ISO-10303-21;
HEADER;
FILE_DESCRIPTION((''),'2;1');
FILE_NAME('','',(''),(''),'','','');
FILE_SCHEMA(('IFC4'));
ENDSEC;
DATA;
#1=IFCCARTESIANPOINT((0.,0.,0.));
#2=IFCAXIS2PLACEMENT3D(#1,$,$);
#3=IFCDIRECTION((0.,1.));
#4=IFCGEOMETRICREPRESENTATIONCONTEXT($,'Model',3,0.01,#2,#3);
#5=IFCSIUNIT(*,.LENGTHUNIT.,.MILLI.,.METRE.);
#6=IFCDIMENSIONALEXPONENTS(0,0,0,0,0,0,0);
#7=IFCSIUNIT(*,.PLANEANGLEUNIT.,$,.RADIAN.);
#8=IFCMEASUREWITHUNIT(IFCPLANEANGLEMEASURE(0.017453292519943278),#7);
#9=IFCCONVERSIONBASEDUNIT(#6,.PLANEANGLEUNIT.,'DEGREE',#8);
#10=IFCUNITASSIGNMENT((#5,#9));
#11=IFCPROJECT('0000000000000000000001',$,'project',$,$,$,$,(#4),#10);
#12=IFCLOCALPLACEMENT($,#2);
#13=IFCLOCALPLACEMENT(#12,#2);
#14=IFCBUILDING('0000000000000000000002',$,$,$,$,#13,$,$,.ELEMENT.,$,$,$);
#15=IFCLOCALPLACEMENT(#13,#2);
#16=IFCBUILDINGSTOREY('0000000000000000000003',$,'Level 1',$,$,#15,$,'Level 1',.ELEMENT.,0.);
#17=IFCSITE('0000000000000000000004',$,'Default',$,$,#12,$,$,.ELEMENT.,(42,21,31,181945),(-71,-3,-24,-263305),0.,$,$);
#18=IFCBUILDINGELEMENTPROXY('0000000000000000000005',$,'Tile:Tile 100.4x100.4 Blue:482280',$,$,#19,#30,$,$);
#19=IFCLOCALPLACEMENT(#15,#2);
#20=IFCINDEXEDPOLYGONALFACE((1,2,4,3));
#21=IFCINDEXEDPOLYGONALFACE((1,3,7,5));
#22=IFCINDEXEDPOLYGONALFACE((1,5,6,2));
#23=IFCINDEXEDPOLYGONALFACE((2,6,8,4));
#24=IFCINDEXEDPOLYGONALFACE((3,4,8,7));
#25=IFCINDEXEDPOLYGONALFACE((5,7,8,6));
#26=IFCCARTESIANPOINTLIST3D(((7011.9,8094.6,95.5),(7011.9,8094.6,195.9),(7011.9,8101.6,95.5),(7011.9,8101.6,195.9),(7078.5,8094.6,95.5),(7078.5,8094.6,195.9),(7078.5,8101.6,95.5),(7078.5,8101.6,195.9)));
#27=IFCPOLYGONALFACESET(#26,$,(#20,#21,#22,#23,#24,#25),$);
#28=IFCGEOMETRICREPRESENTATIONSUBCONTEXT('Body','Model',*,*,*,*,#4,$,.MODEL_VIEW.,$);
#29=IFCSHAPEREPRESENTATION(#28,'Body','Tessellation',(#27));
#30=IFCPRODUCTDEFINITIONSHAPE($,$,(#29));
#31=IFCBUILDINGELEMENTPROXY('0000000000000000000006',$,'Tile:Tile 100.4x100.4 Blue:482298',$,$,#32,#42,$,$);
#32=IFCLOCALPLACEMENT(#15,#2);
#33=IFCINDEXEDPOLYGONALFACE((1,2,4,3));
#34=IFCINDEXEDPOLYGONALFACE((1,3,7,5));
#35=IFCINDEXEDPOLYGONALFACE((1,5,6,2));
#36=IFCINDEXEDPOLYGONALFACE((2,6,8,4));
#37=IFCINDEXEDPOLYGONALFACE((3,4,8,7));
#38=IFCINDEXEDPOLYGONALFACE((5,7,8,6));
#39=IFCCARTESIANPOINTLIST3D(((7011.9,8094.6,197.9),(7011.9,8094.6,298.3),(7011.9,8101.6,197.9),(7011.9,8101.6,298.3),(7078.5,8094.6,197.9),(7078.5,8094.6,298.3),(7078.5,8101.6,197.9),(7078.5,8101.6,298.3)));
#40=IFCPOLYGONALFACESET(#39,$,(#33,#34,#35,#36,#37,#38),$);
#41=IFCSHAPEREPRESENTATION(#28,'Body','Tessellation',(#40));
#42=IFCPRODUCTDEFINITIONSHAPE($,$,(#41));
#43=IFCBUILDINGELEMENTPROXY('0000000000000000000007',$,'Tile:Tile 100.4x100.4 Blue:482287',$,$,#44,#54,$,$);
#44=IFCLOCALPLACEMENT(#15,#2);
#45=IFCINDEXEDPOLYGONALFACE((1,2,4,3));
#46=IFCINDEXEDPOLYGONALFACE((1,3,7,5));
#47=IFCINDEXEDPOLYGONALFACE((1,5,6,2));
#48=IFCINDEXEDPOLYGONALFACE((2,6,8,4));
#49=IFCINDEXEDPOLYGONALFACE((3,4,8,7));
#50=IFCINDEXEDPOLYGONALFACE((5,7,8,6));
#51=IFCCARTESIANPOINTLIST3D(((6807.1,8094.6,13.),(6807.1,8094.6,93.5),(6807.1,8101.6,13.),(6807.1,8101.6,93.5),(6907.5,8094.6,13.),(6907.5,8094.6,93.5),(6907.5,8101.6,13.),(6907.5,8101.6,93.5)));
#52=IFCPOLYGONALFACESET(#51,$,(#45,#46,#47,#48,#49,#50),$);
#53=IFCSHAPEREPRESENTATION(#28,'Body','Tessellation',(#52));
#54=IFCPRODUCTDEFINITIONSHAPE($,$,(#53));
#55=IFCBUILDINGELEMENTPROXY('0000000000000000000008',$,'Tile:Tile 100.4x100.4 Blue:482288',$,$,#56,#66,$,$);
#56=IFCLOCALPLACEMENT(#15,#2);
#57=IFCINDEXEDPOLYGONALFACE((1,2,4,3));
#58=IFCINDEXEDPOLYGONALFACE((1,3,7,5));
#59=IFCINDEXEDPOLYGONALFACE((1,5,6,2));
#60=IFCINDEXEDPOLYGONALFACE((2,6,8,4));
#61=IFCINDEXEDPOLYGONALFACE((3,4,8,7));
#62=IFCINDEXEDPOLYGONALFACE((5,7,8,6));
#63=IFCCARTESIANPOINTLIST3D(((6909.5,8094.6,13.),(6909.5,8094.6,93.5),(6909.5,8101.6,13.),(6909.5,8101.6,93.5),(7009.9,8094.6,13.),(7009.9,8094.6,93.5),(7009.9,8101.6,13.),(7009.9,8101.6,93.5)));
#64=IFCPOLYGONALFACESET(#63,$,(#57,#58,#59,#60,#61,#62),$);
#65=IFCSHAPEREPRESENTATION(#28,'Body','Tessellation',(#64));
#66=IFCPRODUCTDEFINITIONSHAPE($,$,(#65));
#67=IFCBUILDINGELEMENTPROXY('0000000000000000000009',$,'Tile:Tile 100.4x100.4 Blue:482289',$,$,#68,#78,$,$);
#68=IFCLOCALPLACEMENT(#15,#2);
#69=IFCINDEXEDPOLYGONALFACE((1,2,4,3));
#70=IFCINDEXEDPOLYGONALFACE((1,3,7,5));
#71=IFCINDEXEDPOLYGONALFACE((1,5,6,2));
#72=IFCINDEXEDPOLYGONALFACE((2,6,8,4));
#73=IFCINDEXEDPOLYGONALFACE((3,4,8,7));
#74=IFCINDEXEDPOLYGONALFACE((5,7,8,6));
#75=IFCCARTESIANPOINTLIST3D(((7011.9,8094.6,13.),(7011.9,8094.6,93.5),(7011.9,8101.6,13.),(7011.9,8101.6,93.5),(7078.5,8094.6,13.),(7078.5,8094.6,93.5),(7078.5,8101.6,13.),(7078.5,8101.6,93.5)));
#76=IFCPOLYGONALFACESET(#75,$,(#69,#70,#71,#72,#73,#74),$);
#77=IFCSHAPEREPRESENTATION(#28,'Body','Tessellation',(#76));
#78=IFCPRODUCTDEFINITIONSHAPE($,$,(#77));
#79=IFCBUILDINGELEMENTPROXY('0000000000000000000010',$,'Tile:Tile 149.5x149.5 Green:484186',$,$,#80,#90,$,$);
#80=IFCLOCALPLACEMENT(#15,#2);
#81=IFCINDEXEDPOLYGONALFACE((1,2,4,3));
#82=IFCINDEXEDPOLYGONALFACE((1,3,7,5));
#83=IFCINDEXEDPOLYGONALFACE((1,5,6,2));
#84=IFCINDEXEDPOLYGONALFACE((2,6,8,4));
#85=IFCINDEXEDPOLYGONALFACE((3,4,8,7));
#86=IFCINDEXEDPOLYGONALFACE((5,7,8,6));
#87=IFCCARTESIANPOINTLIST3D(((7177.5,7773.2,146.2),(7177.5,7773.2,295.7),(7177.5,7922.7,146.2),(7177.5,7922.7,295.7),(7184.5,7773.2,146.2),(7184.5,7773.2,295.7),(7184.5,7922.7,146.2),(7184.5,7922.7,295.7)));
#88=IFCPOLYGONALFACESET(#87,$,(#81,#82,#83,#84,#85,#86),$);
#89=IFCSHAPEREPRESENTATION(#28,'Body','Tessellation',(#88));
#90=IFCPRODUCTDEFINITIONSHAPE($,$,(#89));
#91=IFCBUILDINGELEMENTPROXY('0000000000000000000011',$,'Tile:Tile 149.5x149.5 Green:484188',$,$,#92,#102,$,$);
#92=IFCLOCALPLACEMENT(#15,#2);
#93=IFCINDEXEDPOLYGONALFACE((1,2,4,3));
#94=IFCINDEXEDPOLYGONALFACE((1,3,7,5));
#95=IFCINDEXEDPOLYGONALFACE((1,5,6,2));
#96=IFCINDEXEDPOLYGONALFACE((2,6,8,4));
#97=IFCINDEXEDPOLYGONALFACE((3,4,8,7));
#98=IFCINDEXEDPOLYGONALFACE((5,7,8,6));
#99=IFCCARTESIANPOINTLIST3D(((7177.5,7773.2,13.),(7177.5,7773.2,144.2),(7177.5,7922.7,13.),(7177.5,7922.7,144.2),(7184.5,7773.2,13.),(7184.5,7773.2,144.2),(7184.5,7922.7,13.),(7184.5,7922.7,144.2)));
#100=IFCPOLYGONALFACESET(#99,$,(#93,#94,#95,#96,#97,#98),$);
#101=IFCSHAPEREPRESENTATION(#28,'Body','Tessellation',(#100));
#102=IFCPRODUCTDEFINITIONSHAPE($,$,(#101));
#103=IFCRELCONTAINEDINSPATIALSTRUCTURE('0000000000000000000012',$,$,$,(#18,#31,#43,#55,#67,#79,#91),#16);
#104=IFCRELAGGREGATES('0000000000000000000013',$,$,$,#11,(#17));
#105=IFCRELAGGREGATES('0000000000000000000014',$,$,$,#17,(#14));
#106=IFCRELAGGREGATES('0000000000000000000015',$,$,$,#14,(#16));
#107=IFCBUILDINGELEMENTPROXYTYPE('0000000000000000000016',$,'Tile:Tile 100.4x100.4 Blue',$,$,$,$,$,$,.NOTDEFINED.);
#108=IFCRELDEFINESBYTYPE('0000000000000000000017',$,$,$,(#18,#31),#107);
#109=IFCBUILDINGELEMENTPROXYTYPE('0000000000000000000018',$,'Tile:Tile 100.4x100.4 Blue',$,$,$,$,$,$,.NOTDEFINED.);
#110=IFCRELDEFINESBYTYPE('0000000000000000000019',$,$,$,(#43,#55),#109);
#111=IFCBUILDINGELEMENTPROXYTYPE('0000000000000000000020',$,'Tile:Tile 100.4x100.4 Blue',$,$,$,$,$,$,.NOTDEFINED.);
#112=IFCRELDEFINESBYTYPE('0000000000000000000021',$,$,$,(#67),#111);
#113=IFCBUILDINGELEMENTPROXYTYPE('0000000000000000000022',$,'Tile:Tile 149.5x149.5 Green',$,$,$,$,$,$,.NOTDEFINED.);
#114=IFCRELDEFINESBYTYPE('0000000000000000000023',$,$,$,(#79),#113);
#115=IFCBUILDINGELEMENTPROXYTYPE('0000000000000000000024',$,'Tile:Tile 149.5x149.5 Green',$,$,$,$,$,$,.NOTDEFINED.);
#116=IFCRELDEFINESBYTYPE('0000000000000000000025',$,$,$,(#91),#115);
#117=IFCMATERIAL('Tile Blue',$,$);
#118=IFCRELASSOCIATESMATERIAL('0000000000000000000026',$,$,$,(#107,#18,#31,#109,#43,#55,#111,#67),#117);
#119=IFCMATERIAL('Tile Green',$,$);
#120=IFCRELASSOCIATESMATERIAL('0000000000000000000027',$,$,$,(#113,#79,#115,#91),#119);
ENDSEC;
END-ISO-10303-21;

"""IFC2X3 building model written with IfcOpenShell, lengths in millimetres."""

from ifc_helpers import new_model, entity, si_unit, converted_unit, direction, frame, origin, origin_2d_with_axis, place, context, subcontext, project, spatial, rectangle, extrude, source, transform, mapped, material, type_object, type_shapes, element, save


model = new_model("IFC2X3")

# Units and contexts
model_context = context("Model", 3, precision=0.01, world=origin(), true_north=direction((0.0, 1.0)))
body_context = subcontext(model_context, "Body", "Model", "MODEL_VIEW")
ifc_project = project(units=[si_unit("LENGTHUNIT", "METRE", prefix="MILLI"), converted_unit("PLANEANGLEUNIT", "DEGREE", entity("IfcPlaneAngleMeasure", 0.017453292519943278), si_unit("PLANEANGLEUNIT", "RADIAN"), dimensions=[0, 0, 0, 0, 0, 0, 0])], contexts=[model_context])

# Site, building, storey
site_placement = place(None, origin())
site = spatial("IfcSite", under=ifc_project, at=site_placement, Name="Default", CompositionType="ELEMENT", RefLatitude=(42, 21, 31, 181945), RefLongitude=(-71, -3, -24, -263305), RefElevation=0.0)
building_placement = place(site_placement, origin())
building = spatial("IfcBuilding", under=site, at=building_placement, CompositionType="ELEMENT")
storey_placement = place(building_placement, origin())
storey = spatial("IfcBuildingStorey", under=building, at=storey_placement, Name="Level 1", LongName="Level 1", CompositionType="ELEMENT", Elevation=0.0)

# Building element proxies
ifc_material_1 = material(Name="Tile Blue")
building_element_proxy_type_1 = type_object("IfcBuildingElementProxyType", Name="Tile:Tile 100.4x100.4 Blue", PredefinedType="NOTDEFINED", material=ifc_material_1)
shared_shape_1 = source(origin(), body_context, "Body", "SweptSolid", [
    extrude(rectangle(XDim=66.6, YDim=100.4, at=origin_2d_with_axis()), frame((-33.3, -50.2, 0.0), z_axis=(0.0, 0.0, 1.0), x_axis=(-1.0, 0.0, 0.0)), (0.0, 0.0, 1.0), 7.0),
])
type_shapes(building_element_proxy_type_1, [shared_shape_1])
for number, where, z_axis, x_axis, name in (
    (1, (7011.9, 8101.6, 95.5), (0.0, -1.0, 0.0), (-1.0, 0.0, 0.0), "Tile:Tile 100.4x100.4 Blue:482280"),
    (2, (7011.9, 8101.6, 197.9), (0.0, -1.0, 0.0), (-1.0, 0.0, 0.0), "Tile:Tile 100.4x100.4 Blue:482298"),
):
    element("IfcBuildingElementProxy", number, at=place(storey_placement, frame(where, z_axis=z_axis, x_axis=x_axis)), inside=storey, type_object=building_element_proxy_type_1, material=ifc_material_1, Name=name, context=body_context, shape_type="MappedRepresentation", body=[
        mapped(shared_shape_1, transform((0.0, 0.0, 0.0), scale=1.0)),
    ])
building_element_proxy_type_2 = type_object("IfcBuildingElementProxyType", Name="Tile:Tile 100.4x100.4 Blue", PredefinedType="NOTDEFINED", material=ifc_material_1)
shared_shape_2 = source(origin(), body_context, "Body", "SweptSolid", [
    extrude(rectangle(XDim=80.5, YDim=100.4, at=origin_2d_with_axis()), frame((-50.2, -40.3, 0.0), z_axis=(0.0, 0.0, 1.0), x_axis=(0.0, -1.0, 0.0)), (0.0, 0.0, 1.0), 7.0),
])
type_shapes(building_element_proxy_type_2, [shared_shape_2])
for number, where, z_axis, x_axis, name in (
    (3, (6807.1, 8101.6, 13.0), (0.0, -1.0, 0.0), (-1.0, 0.0, 0.0), "Tile:Tile 100.4x100.4 Blue:482287"),
    (4, (6909.5, 8101.6, 13.0), (0.0, -1.0, 0.0), (-1.0, 0.0, 0.0), "Tile:Tile 100.4x100.4 Blue:482288"),
):
    element("IfcBuildingElementProxy", number, at=place(storey_placement, frame(where, z_axis=z_axis, x_axis=x_axis)), inside=storey, type_object=building_element_proxy_type_2, material=ifc_material_1, Name=name, context=body_context, shape_type="MappedRepresentation", body=[
        mapped(shared_shape_2, transform((0.0, 0.0, 0.0), scale=1.0)),
    ])
building_element_proxy_type_3 = type_object("IfcBuildingElementProxyType", Name="Tile:Tile 100.4x100.4 Blue", PredefinedType="NOTDEFINED", material=ifc_material_1)
shared_shape_3 = source(origin(), body_context, "Body", "SweptSolid", [
    extrude(rectangle(XDim=66.6, YDim=80.5, at=origin_2d_with_axis()), frame((-33.3, -40.3, 0.0), z_axis=(0.0, 0.0, 1.0), x_axis=(-1.0, 0.0, 0.0)), (0.0, 0.0, 1.0), 7.0),
])
type_shapes(building_element_proxy_type_3, [shared_shape_3])
proxy_1_placement = place(storey_placement, frame((7011.9, 8101.6, 13.0), z_axis=(0.0, -1.0, 0.0), x_axis=(-1.0, 0.0, 0.0)))
element("IfcBuildingElementProxy", 5, at=proxy_1_placement, inside=storey, type_object=building_element_proxy_type_3, material=ifc_material_1, Name="Tile:Tile 100.4x100.4 Blue:482289", context=body_context, shape_type="MappedRepresentation", body=[
    mapped(shared_shape_3, transform((0.0, 0.0, 0.0), scale=1.0)),
])
ifc_material_2 = material(Name="Tile Green")
building_element_proxy_type_4 = type_object("IfcBuildingElementProxyType", Name="Tile:Tile 149.5x149.5 Green", PredefinedType="NOTDEFINED", material=ifc_material_2)
shared_shape_4 = source(origin(), body_context, "Body", "SweptSolid", [
    extrude(rectangle(XDim=149.5, YDim=149.5, at=origin_2d_with_axis()), frame((-74.7, -74.8, 0.0), z_axis=(0.0, 0.0, 1.0), x_axis=(0.0, -1.0, 0.0)), (0.0, 0.0, 1.0), 7.0),
])
type_shapes(building_element_proxy_type_4, [shared_shape_4])
proxy_2_placement = place(storey_placement, frame((7184.5, 7922.7, 295.7), z_axis=(-1.0, 0.0, 0.0), x_axis=(0.0, 0.0, 1.0)))
element("IfcBuildingElementProxy", 6, at=proxy_2_placement, inside=storey, type_object=building_element_proxy_type_4, material=ifc_material_2, Name="Tile:Tile 149.5x149.5 Green:484186", context=body_context, shape_type="MappedRepresentation", body=[
    mapped(shared_shape_4, transform((0.0, 0.0, 0.0), scale=1.0)),
])
building_element_proxy_type_5 = type_object("IfcBuildingElementProxyType", Name="Tile:Tile 149.5x149.5 Green", PredefinedType="NOTDEFINED", material=ifc_material_2)
shared_shape_5 = source(origin(), body_context, "Body", "SweptSolid", [
    extrude(rectangle(XDim=131.2, YDim=149.5, at=origin_2d_with_axis()), frame((-65.6, -74.8, 0.0), z_axis=(0.0, 0.0, 1.0), x_axis=(-1.0, 0.0, 0.0)), (0.0, 0.0, 1.0), 7.0),
])
type_shapes(building_element_proxy_type_5, [shared_shape_5])
proxy_3_placement = place(storey_placement, frame((7184.5, 7922.7, 144.2), z_axis=(-1.0, 0.0, 0.0), x_axis=(0.0, 0.0, 1.0)))
element("IfcBuildingElementProxy", 7, at=proxy_3_placement, inside=storey, type_object=building_element_proxy_type_5, material=ifc_material_2, Name="Tile:Tile 149.5x149.5 Green:484188", context=body_context, shape_type="MappedRepresentation", body=[
    mapped(shared_shape_5, transform((0.0, 0.0, 0.0), scale=1.0)),
])

save(model, "model.ifc")
